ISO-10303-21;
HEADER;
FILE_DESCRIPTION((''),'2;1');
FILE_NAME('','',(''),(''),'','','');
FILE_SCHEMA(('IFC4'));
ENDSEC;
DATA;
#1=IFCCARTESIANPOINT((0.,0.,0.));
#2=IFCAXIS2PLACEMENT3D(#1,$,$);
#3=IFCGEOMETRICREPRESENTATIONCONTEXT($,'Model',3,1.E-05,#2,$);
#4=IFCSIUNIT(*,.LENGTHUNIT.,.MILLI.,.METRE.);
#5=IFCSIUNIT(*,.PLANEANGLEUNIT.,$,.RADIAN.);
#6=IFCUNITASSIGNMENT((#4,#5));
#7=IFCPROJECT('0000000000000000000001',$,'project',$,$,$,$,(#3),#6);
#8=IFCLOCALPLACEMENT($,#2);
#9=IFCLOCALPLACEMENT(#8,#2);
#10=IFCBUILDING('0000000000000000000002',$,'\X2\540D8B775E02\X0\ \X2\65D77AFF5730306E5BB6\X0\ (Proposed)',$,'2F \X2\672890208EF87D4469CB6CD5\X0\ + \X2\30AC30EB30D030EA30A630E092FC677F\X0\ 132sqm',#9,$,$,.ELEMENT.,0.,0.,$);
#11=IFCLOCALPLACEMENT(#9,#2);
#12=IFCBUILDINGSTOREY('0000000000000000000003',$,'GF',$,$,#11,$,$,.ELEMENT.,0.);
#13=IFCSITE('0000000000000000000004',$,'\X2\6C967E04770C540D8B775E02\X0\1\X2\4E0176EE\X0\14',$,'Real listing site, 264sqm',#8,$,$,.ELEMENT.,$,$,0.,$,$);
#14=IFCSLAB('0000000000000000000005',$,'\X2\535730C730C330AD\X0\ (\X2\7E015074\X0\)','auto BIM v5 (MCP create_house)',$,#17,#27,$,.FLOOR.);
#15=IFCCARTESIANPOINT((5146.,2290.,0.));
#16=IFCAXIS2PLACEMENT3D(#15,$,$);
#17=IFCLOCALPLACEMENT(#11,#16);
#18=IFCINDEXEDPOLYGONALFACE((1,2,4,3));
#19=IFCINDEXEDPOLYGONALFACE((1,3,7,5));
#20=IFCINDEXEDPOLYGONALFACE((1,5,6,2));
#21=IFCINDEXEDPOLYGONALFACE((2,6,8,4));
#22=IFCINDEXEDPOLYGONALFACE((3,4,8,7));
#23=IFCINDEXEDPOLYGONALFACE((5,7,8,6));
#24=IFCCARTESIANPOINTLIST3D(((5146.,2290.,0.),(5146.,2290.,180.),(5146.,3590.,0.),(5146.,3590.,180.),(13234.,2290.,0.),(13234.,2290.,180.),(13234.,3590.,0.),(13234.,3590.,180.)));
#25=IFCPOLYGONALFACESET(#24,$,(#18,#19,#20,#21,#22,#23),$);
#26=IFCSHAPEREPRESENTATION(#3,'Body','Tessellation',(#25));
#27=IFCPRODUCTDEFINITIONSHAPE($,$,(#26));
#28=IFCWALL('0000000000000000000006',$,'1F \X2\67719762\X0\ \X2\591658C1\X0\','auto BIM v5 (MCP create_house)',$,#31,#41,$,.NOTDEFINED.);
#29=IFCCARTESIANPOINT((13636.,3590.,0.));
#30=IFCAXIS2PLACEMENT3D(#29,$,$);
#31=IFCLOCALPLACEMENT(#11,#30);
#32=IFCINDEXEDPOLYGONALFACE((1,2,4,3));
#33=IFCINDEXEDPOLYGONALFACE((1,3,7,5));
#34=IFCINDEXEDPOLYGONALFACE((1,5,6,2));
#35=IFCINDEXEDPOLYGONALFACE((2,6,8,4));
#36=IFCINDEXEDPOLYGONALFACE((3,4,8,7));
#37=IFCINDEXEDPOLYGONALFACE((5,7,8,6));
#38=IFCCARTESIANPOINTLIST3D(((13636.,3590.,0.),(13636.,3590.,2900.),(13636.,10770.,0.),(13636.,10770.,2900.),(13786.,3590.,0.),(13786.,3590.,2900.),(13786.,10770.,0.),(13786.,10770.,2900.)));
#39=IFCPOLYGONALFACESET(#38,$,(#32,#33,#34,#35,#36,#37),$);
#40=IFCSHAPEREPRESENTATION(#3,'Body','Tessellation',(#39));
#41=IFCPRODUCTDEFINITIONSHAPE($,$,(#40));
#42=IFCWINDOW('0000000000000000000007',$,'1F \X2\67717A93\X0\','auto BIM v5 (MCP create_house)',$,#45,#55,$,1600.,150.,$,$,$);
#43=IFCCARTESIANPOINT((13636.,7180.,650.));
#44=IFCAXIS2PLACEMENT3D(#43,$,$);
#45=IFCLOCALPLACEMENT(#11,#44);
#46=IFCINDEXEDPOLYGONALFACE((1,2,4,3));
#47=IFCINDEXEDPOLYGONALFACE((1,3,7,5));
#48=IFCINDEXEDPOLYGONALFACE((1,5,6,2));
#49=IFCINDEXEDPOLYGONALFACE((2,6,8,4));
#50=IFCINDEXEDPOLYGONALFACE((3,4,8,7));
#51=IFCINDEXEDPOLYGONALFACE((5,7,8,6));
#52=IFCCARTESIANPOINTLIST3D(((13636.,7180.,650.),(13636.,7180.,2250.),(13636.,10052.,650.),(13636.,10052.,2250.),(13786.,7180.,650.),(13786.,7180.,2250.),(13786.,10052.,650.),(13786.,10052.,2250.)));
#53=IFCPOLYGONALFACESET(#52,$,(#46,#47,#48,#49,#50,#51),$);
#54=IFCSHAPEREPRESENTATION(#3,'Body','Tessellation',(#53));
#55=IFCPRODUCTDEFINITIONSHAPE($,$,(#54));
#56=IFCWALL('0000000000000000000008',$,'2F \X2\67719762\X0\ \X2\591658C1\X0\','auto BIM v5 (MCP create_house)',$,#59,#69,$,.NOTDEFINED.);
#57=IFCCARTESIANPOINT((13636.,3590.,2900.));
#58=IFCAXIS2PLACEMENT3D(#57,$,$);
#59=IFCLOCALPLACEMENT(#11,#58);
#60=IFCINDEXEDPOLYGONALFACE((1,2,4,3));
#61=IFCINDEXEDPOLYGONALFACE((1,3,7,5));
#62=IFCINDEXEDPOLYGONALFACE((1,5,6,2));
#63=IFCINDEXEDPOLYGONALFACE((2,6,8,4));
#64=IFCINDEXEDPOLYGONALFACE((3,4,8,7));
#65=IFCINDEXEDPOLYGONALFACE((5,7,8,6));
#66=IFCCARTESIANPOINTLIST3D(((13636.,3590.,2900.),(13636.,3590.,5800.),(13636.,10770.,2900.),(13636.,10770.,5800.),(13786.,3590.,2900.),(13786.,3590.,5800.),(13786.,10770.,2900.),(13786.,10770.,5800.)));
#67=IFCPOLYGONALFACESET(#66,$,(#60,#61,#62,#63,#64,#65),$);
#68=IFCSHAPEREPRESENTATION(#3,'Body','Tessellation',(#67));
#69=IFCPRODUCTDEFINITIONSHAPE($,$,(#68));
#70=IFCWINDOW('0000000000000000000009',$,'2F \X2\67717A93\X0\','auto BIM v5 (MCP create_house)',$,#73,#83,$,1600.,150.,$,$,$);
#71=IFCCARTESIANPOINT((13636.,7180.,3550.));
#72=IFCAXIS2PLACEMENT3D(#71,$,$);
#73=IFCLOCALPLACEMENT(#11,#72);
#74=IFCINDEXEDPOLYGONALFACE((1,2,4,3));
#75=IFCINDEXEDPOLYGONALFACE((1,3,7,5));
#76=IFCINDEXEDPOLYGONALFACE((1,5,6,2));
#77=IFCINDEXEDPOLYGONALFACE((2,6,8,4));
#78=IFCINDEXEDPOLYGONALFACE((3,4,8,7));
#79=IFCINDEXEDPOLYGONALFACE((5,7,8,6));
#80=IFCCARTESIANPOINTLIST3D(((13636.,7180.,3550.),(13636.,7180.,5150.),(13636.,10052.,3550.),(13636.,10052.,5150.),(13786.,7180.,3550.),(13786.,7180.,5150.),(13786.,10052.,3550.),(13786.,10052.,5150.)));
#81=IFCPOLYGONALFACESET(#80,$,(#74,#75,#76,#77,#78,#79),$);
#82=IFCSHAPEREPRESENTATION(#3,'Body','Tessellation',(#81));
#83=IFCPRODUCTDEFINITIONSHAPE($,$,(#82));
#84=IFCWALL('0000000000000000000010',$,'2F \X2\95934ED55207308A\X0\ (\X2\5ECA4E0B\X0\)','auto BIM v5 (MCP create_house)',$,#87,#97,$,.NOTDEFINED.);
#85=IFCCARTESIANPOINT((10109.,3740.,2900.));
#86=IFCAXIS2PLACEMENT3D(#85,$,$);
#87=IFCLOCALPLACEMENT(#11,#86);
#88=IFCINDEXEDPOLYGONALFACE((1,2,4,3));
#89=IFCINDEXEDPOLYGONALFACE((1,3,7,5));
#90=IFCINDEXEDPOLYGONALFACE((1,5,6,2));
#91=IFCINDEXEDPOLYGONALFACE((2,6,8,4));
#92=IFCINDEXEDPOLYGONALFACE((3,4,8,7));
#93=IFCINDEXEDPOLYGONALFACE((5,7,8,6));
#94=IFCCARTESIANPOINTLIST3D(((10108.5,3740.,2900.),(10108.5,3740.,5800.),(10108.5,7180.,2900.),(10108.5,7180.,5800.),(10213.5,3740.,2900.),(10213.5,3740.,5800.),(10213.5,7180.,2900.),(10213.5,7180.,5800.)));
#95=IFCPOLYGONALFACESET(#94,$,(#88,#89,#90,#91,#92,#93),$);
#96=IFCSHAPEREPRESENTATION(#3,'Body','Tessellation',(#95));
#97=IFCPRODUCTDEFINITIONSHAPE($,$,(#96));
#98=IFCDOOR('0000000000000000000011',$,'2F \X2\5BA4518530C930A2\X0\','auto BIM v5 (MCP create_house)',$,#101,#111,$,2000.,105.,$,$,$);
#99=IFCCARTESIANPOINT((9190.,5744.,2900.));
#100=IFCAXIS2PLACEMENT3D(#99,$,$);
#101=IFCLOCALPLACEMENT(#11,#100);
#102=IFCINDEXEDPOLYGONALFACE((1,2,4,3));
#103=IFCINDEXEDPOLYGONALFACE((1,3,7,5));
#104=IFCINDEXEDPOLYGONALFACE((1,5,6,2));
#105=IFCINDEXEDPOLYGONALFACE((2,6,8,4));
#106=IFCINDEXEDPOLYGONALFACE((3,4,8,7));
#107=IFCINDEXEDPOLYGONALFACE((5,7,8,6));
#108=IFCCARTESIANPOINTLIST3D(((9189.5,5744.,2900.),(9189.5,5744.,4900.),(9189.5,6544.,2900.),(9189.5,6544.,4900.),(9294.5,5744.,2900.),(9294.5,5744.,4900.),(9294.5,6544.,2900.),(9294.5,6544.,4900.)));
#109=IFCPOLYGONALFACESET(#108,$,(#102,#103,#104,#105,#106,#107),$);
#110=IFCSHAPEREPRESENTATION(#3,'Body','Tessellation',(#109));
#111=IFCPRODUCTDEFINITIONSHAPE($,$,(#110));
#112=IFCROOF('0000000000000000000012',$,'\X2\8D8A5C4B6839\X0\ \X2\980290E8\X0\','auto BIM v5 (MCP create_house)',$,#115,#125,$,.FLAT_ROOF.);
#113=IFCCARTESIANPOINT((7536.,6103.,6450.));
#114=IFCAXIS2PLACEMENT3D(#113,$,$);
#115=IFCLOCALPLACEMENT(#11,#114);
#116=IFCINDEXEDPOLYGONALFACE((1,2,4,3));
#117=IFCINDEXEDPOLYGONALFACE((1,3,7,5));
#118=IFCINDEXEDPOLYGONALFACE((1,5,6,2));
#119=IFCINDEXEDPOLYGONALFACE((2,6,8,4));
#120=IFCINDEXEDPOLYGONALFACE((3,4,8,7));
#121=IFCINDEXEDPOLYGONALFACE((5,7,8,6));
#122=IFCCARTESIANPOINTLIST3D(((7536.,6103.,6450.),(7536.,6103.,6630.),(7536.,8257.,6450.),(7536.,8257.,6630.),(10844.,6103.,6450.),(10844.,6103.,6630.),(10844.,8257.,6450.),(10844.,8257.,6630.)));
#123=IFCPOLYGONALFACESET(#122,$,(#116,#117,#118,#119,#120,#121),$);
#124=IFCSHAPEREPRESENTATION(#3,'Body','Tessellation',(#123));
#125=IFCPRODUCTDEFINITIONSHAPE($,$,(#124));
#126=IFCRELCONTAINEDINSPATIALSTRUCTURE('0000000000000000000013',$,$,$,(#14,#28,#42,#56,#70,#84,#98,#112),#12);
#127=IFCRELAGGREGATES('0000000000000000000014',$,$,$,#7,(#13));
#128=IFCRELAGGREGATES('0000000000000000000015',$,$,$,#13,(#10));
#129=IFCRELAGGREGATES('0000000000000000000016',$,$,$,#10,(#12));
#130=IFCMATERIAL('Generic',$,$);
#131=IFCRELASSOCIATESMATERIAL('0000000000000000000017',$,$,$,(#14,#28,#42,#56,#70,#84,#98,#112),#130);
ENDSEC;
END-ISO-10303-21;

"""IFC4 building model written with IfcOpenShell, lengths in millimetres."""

from ifc_helpers import new_model, si_unit, frame, frame_2d, origin, place, context, project, spatial, rectangle, extrude, material, element, fill, save


model = new_model("IFC4")

# Units and contexts
model_context = context("Model", 3, precision=1e-05, world=origin())
ifc_project = project(units=[si_unit("LENGTHUNIT", "METRE", prefix="MILLI"), si_unit("PLANEANGLEUNIT", "RADIAN")], contexts=[model_context])

# Site, building, storey
site_placement = place(None, origin())
site = spatial("IfcSite", under=ifc_project, at=site_placement, Name="沖縄県名護市1丁目14", ObjectType="Real listing site, 264sqm", CompositionType="ELEMENT", RefElevation=0.0)
building_placement = place(site_placement, origin())
building = spatial("IfcBuilding", under=site, at=building_placement, Name="名護市 旗竿地の家 (Proposed)", ObjectType="2F 木造軸組構法 + ガルバリウム鋼板 132sqm", CompositionType="ELEMENT", ElevationOfRefHeight=0.0, ElevationOfTerrain=0.0)
storey_placement = place(building_placement, origin())
storey = spatial("IfcBuildingStorey", under=building, at=storey_placement, Name="GF", CompositionType="ELEMENT", Elevation=0.0)

# Slab
ifc_material = material(Name="Generic")
slab_placement = place(storey_placement, frame((5146.0, 2290.0, 0.0)))
element("IfcSlab", 1, at=slab_placement, inside=storey, material=ifc_material, Name="南デッキ (縁側)", Description="auto BIM v5 (MCP create_house)", PredefinedType="FLOOR", context=model_context, shape_type="SweptSolid", body=[
    extrude(rectangle(XDim=8088.0, YDim=1300.0, at=frame_2d((4044.0, 650.0))), frame((5146.0, 2290.0, 0.0)), (0.0, 0.0, 1.0), 180.0),
])

# Wall, opening, window
wall_1_placement = place(storey_placement, frame((13636.0, 3590.0, 0.0)))
wall_1 = element("IfcWall", 2, at=wall_1_placement, inside=storey, material=ifc_material, Name="1F 東面 外壁", Description="auto BIM v5 (MCP create_house)", PredefinedType="NOTDEFINED", context=model_context, shape_type="SweptSolid", body=[
    extrude(rectangle(XDim=150.0, YDim=7180.0, at=frame_2d((75.0, 3590.0))), frame((13636.0, 3590.0, 0.0)), (0.0, 0.0, 1.0), 2900.0),
])
opening_1_placement = place(storey_placement, frame((13636.0, 7180.0, 650.0)))
opening_1 = element("IfcOpeningElement", 3, at=opening_1_placement, cuts=wall_1, PredefinedType="NOTDEFINED", context=model_context, shape_type="SweptSolid", body=[
    extrude(rectangle(XDim=150.0, YDim=2872.0, at=frame_2d((75.0, 1436.0))), frame((13636.0, 7180.0, 650.0)), (0.0, 0.0, 1.0), 1600.0),
])
window_1_placement = place(storey_placement, frame((13636.0, 7180.0, 650.0)))
window_1 = element("IfcWindow", 4, at=window_1_placement, inside=storey, material=ifc_material, Name="1F 東窓", Description="auto BIM v5 (MCP create_house)", OverallHeight=1600.0, OverallWidth=150.0, context=model_context, shape_type="SweptSolid", body=[
    extrude(rectangle(XDim=150.0, YDim=2872.0, at=frame_2d((75.0, 1436.0))), frame((13636.0, 7180.0, 650.0)), (0.0, 0.0, 1.0), 1600.0),
])
fill(opening_1, window_1)

# Wall, opening, window
wall_2_placement = place(storey_placement, frame((13636.0, 3590.0, 2900.0)))
wall_2 = element("IfcWall", 5, at=wall_2_placement, inside=storey, material=ifc_material, Name="2F 東面 外壁", Description="auto BIM v5 (MCP create_house)", PredefinedType="NOTDEFINED", context=model_context, shape_type="SweptSolid", body=[
    extrude(rectangle(XDim=150.0, YDim=7180.0, at=frame_2d((75.0, 3590.0))), frame((13636.0, 3590.0, 2900.0)), (0.0, 0.0, 1.0), 2900.0),
])
opening_2_placement = place(storey_placement, frame((13636.0, 7180.0, 3550.0)))
opening_2 = element("IfcOpeningElement", 6, at=opening_2_placement, cuts=wall_2, PredefinedType="NOTDEFINED", context=model_context, shape_type="SweptSolid", body=[
    extrude(rectangle(XDim=150.0, YDim=2872.0, at=frame_2d((75.0, 1436.0))), frame((13636.0, 7180.0, 3550.0)), (0.0, 0.0, 1.0), 1600.0),
])
window_2_placement = place(storey_placement, frame((13636.0, 7180.0, 3550.0)))
window_2 = element("IfcWindow", 7, at=window_2_placement, inside=storey, material=ifc_material, Name="2F 東窓", Description="auto BIM v5 (MCP create_house)", OverallHeight=1600.0, OverallWidth=150.0, context=model_context, shape_type="SweptSolid", body=[
    extrude(rectangle(XDim=150.0, YDim=2872.0, at=frame_2d((75.0, 1436.0))), frame((13636.0, 7180.0, 3550.0)), (0.0, 0.0, 1.0), 1600.0),
])
fill(opening_2, window_2)

# Wall
wall_3_placement = place(storey_placement, frame((10109.0, 3740.0, 2900.0)))
element("IfcWall", 8, at=wall_3_placement, inside=storey, material=ifc_material, Name="2F 間仕切り (廊下)", Description="auto BIM v5 (MCP create_house)", PredefinedType="NOTDEFINED", context=model_context, shape_type="SweptSolid", body=[
    extrude(rectangle(XDim=105.0, YDim=3440.0, at=frame_2d((52.0, 1720.0))), frame((10109.0, 3740.0, 2900.0)), (0.0, 0.0, 1.0), 2900.0),
])

# Door
door_placement = place(storey_placement, frame((9190.0, 5744.0, 2900.0)))
element("IfcDoor", 9, at=door_placement, inside=storey, material=ifc_material, Name="2F 室内ドア", Description="auto BIM v5 (MCP create_house)", OverallHeight=2000.0, OverallWidth=105.0, context=model_context, shape_type="SweptSolid", body=[
    extrude(rectangle(XDim=105.0, YDim=800.0, at=frame_2d((52.0, 400.0))), frame((9190.0, 5744.0, 2900.0)), (0.0, 0.0, 1.0), 2000.0),
])

# Roof
roof_placement = place(storey_placement, frame((7536.0, 6103.0, 6450.0)))
element("IfcRoof", 10, at=roof_placement, inside=storey, material=ifc_material, Name="越屋根 頂部", Description="auto BIM v5 (MCP create_house)", PredefinedType="FLAT_ROOF", context=model_context, shape_type="SweptSolid", body=[
    extrude(rectangle(XDim=3308.0, YDim=2154.0, at=frame_2d((1654.0, 1077.0))), frame((7536.0, 6103.0, 6450.0)), (0.0, 0.0, 1.0), 180.0),
])

save(model, "model.ifc")
